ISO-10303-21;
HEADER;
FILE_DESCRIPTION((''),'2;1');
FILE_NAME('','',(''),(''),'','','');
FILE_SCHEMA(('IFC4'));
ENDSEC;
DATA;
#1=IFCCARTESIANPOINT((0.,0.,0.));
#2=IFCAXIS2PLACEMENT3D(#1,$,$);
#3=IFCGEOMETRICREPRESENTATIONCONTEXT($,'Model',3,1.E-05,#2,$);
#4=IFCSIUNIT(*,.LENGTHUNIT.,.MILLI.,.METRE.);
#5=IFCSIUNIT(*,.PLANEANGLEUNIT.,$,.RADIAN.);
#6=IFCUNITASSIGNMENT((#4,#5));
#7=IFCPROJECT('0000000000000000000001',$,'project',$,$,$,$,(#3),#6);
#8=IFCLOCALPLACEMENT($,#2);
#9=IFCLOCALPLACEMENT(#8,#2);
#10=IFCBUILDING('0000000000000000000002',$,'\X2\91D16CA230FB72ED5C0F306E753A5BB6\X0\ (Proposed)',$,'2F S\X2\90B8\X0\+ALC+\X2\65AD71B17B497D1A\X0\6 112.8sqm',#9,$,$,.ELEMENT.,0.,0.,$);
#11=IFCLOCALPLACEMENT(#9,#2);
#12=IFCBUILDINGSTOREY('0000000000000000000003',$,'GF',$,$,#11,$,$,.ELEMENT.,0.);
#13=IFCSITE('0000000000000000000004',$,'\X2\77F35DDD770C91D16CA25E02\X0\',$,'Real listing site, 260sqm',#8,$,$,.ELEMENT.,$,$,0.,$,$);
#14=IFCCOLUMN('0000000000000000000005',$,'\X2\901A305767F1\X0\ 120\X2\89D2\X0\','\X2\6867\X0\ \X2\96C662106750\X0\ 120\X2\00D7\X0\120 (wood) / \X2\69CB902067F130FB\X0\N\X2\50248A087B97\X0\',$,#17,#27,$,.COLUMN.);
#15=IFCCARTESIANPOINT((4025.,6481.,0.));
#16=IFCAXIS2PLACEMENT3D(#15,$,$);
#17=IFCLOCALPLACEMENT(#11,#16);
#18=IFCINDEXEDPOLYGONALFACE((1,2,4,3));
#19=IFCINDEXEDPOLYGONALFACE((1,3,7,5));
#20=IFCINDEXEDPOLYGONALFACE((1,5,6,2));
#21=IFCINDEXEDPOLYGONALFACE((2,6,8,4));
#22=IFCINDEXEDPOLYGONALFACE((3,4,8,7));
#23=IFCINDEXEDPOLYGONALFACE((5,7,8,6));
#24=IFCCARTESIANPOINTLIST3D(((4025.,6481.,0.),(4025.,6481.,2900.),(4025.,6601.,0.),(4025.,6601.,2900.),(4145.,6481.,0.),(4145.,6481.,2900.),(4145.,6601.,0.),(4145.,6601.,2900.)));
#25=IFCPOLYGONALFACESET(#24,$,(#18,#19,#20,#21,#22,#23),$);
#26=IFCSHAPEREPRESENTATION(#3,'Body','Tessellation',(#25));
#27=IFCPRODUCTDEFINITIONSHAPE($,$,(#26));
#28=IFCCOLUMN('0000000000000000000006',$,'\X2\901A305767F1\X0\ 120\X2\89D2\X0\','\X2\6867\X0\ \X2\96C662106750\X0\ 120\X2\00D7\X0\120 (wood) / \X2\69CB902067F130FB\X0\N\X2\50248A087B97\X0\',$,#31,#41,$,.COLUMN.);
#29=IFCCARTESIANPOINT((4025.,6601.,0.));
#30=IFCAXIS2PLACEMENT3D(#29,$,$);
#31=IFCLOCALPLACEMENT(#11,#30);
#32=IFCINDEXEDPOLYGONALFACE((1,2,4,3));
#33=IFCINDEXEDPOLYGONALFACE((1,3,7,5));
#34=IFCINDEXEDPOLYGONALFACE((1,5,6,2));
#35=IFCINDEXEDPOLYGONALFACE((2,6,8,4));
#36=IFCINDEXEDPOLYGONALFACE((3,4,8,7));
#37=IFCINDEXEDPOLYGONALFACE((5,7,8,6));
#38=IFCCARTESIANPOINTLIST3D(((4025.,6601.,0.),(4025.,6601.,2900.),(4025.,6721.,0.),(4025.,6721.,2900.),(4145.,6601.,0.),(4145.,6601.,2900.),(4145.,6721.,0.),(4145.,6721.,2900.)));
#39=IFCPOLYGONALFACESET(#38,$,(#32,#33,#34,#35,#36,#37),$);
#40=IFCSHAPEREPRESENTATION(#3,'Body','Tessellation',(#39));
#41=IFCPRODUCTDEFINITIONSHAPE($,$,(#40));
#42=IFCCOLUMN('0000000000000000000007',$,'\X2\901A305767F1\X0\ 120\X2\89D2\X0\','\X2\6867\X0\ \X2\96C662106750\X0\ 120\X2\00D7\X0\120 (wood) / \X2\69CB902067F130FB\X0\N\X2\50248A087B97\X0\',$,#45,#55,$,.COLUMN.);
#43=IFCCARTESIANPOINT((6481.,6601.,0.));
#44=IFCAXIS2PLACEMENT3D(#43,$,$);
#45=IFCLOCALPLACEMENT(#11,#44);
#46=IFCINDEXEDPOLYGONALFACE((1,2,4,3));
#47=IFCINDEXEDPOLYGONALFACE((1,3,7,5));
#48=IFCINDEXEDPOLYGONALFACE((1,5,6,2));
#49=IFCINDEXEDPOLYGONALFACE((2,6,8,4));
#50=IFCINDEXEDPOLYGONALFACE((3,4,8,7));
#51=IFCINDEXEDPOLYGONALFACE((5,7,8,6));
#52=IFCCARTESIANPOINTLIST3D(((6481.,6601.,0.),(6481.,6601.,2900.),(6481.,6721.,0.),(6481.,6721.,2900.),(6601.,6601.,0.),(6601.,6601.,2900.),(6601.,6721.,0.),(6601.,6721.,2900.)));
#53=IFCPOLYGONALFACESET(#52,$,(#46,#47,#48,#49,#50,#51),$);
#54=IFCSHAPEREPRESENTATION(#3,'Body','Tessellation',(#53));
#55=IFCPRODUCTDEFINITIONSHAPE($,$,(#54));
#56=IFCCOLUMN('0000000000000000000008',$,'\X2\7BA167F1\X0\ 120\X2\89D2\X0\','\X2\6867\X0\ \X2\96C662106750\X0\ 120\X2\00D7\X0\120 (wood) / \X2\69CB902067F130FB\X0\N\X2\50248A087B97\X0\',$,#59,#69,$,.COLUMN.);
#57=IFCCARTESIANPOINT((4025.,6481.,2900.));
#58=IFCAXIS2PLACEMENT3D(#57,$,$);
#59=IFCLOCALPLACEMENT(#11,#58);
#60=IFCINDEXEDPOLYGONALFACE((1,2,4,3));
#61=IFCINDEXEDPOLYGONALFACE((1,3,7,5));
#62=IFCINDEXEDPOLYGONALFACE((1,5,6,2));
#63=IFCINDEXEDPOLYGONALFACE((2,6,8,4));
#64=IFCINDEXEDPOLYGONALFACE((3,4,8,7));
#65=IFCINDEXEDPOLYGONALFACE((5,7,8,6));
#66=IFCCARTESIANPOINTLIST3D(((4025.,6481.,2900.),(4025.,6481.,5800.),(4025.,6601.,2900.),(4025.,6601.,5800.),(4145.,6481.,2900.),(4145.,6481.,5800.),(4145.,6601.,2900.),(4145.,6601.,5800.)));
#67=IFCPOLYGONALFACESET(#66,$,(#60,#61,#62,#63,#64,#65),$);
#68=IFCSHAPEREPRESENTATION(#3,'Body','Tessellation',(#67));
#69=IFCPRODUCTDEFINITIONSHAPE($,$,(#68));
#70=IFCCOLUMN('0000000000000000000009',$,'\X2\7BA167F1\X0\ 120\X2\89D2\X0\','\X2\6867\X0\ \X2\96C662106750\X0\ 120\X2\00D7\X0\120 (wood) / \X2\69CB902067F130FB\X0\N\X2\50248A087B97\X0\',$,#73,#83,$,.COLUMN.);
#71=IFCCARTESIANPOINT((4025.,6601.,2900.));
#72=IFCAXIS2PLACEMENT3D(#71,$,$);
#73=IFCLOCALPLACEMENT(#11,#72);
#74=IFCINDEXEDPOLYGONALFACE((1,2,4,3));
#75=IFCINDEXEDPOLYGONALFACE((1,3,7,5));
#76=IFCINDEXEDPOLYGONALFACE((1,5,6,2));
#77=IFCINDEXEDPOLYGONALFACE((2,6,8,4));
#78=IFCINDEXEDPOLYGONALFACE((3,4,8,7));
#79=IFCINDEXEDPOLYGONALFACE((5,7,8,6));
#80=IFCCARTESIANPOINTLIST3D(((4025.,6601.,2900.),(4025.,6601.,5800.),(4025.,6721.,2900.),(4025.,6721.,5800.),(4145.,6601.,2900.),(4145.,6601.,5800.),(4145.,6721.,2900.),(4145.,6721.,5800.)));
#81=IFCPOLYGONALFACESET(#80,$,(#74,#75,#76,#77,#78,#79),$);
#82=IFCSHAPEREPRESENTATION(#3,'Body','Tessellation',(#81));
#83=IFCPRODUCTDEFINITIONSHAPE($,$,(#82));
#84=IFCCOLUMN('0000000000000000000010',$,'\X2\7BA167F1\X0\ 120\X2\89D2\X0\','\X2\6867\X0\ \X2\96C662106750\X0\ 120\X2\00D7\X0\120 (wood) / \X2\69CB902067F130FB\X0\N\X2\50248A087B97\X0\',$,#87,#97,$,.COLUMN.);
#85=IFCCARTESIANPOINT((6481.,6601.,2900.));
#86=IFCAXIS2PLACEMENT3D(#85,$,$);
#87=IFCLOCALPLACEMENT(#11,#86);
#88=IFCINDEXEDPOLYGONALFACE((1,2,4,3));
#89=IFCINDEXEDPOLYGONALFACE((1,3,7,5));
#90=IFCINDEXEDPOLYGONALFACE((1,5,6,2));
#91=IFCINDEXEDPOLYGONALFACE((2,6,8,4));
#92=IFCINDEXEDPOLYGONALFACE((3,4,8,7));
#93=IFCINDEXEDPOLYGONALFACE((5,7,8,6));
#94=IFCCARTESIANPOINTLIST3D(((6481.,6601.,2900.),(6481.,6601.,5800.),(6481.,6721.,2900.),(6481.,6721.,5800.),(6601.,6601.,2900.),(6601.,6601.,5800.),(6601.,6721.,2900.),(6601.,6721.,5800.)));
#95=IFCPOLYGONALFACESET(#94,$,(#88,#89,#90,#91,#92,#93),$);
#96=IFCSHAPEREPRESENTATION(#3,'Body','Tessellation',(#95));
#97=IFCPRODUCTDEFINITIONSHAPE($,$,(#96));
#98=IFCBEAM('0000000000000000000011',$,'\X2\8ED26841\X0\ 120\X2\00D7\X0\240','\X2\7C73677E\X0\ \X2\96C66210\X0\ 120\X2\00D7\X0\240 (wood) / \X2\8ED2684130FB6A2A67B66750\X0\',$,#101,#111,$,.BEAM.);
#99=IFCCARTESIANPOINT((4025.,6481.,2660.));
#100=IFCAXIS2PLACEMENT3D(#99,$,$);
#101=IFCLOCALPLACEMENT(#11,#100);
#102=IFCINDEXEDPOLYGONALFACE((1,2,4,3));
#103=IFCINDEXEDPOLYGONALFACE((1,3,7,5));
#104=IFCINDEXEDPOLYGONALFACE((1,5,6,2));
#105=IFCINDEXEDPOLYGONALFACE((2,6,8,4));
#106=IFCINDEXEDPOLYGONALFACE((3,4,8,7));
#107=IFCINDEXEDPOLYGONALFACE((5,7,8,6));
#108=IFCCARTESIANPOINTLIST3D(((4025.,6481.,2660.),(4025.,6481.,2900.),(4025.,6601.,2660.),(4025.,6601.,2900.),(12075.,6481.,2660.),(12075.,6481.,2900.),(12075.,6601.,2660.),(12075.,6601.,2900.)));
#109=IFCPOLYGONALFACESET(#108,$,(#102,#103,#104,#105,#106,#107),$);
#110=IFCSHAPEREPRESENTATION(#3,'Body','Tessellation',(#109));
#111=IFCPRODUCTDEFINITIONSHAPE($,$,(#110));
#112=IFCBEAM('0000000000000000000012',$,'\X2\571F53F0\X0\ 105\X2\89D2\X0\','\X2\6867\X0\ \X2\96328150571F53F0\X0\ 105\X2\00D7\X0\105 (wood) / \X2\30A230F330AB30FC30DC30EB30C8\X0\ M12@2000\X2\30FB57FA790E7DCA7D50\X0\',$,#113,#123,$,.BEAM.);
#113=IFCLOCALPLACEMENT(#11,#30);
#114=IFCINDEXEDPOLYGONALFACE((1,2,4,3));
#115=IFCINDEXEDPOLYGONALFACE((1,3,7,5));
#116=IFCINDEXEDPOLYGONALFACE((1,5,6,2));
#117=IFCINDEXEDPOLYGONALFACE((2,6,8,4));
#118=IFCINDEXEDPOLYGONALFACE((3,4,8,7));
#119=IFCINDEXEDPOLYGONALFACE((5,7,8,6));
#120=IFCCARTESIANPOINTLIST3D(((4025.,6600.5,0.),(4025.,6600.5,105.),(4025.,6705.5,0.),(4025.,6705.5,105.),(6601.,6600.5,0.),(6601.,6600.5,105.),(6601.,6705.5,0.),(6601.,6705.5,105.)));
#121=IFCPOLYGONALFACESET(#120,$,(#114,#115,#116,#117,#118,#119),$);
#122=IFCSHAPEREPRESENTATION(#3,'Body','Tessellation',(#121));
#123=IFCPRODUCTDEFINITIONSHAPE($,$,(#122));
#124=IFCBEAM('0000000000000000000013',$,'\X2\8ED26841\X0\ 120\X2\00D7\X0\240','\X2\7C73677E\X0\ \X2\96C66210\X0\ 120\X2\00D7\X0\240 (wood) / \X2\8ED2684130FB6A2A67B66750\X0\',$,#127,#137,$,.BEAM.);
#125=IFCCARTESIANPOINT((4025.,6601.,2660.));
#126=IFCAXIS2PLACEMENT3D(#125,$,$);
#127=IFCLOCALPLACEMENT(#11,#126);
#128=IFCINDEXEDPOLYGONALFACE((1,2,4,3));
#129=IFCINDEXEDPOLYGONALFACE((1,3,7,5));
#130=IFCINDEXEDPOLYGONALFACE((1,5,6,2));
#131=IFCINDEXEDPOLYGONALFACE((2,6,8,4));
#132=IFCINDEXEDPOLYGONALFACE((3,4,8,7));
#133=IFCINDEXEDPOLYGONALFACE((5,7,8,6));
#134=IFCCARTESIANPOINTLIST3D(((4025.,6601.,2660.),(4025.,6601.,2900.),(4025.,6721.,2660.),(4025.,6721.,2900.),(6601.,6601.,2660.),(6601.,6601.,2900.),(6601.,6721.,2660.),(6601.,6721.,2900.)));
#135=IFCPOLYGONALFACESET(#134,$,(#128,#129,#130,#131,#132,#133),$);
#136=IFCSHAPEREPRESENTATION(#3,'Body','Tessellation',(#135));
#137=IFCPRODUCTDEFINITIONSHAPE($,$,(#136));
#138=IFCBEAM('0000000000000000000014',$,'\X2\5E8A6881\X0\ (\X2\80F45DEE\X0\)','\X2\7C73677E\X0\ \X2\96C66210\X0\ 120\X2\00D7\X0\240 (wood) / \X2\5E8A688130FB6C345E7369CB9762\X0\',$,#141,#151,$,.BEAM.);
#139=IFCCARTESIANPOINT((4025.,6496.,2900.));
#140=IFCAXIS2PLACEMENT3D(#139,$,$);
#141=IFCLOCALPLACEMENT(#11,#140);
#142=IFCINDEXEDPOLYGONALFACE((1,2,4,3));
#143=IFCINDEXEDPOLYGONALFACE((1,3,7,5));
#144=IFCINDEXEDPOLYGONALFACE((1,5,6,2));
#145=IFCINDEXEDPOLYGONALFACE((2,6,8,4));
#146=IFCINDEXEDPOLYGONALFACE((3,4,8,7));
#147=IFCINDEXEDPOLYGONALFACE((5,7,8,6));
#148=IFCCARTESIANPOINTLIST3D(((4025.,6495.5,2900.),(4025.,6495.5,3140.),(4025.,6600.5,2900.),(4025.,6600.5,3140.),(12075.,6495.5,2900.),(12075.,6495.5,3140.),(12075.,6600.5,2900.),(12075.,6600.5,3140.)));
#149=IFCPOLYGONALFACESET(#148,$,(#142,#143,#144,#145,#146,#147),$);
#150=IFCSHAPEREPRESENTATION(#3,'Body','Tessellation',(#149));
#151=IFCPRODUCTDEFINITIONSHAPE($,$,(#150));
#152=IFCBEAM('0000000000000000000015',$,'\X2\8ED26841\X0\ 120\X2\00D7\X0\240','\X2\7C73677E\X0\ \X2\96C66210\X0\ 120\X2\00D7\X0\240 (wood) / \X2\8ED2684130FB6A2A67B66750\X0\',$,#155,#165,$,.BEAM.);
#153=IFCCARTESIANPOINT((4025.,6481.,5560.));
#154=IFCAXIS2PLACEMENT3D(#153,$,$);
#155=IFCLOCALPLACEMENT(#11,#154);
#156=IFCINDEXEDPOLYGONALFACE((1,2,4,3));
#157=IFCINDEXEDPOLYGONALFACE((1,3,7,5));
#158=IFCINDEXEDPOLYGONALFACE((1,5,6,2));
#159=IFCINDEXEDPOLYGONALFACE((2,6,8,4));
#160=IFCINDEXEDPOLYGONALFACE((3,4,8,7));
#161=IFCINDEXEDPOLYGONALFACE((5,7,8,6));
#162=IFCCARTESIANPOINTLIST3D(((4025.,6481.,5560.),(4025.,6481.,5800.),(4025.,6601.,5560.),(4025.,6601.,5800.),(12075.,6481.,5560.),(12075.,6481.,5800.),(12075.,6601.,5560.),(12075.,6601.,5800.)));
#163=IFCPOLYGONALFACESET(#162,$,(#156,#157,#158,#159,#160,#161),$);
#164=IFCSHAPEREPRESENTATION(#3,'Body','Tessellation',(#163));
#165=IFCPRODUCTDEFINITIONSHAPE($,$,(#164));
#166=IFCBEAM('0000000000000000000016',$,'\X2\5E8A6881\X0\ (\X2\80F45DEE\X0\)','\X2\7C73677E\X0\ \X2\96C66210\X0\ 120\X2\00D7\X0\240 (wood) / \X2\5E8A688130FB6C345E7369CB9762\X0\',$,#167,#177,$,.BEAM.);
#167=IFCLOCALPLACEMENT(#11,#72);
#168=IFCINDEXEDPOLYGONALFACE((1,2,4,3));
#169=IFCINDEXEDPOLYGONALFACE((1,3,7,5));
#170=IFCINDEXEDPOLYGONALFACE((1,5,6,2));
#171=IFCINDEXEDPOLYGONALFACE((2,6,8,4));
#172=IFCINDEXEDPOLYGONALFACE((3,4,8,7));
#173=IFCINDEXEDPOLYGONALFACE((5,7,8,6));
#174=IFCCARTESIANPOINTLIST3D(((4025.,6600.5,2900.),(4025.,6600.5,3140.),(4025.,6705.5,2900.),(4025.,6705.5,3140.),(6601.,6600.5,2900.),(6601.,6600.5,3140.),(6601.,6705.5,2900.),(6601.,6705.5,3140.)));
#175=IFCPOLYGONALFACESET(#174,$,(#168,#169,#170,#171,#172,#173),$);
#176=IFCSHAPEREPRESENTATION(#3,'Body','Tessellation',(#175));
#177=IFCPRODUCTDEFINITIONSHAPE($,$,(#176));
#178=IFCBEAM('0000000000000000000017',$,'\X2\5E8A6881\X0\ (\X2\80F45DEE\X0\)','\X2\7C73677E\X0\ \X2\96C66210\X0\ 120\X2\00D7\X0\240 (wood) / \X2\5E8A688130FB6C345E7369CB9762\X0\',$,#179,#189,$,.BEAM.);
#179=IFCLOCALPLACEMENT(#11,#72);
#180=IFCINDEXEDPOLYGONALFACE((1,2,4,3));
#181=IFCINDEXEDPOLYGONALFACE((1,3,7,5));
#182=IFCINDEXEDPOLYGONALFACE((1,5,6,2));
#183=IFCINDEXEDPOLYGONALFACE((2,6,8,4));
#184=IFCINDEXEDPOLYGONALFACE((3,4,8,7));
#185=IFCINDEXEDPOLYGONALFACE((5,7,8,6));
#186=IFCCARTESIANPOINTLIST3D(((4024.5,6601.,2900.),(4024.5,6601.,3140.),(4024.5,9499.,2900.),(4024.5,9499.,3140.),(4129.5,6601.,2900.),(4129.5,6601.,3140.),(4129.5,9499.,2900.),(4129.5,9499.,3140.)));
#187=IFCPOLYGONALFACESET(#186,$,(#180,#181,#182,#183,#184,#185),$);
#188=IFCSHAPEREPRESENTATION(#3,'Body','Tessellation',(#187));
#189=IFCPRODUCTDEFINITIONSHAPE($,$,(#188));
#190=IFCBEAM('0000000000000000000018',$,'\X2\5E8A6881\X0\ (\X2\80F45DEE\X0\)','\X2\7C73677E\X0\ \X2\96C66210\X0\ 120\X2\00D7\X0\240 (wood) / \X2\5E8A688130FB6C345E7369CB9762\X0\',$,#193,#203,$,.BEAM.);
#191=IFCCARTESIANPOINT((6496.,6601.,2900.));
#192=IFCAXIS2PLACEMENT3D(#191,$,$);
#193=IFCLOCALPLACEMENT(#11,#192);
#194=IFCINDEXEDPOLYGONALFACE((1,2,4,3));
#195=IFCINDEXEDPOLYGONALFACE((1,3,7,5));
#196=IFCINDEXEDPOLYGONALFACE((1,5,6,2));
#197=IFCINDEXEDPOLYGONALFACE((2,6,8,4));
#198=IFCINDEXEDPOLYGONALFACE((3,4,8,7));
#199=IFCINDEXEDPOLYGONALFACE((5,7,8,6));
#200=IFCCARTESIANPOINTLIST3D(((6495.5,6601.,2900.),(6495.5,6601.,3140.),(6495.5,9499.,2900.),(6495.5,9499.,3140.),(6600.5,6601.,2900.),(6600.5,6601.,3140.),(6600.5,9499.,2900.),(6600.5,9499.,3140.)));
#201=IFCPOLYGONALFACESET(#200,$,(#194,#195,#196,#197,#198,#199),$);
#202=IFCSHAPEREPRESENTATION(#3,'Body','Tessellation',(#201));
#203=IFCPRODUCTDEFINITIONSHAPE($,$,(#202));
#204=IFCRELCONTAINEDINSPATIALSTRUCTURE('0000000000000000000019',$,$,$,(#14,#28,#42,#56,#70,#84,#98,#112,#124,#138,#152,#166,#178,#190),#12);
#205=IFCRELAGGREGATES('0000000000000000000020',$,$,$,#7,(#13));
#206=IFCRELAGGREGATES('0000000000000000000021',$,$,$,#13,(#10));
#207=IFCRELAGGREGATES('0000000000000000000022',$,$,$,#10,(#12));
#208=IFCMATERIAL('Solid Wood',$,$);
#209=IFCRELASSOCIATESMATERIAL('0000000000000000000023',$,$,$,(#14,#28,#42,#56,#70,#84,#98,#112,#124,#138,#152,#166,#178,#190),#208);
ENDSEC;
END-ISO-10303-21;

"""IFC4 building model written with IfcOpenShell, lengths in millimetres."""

from ifc_helpers import new_model, si_unit, frame, frame_2d, origin, place, context, project, spatial, rectangle, extrude, material, element, save


model = new_model("IFC4")

# Units and contexts
model_context = context("Model", 3, precision=1e-05, world=origin())
ifc_project = project(units=[si_unit("LENGTHUNIT", "METRE", prefix="MILLI"), si_unit("PLANEANGLEUNIT", "RADIAN")], contexts=[model_context])

# Site, building, storey
site_placement = place(None, origin())
site = spatial("IfcSite", under=ifc_project, at=site_placement, Name="石川県金沢市", ObjectType="Real listing site, 260sqm", CompositionType="ELEMENT", RefElevation=0.0)
building_placement = place(site_placement, origin())
building = spatial("IfcBuilding", under=site, at=building_placement, Name="金沢・狭小の町家 (Proposed)", ObjectType="2F S邸+ALC+断熱等級6 112.8sqm", CompositionType="ELEMENT", ElevationOfRefHeight=0.0, ElevationOfTerrain=0.0)
storey_placement = place(building_placement, origin())
storey = spatial("IfcBuildingStorey", under=building, at=storey_placement, Name="GF", CompositionType="ELEMENT", Elevation=0.0)

# Columns
ifc_material_1 = material(Name="Solid Wood")
column_1_placement = place(storey_placement, frame((4025.0, 6481.0, 0.0)))
element("IfcColumn", 1, at=column_1_placement, inside=storey, material=ifc_material_1, Name="通し柱 120角", Description="桧 集成材 120×120 (wood) / 構造柱・N値計算", PredefinedType="COLUMN", context=model_context, shape_type="SweptSolid", body=[
    extrude(rectangle(XDim=120.0, YDim=120.0, at=frame_2d((60.0, 60.0))), frame((4025.0, 6481.0, 0.0)), (0.0, 0.0, 1.0), 2900.0),
])
column_2_placement = place(storey_placement, frame((4025.0, 6601.0, 0.0)))
element("IfcColumn", 2, at=column_2_placement, inside=storey, material=ifc_material_1, Name="通し柱 120角", Description="桧 集成材 120×120 (wood) / 構造柱・N値計算", PredefinedType="COLUMN", context=model_context, shape_type="SweptSolid", body=[
    extrude(rectangle(XDim=120.0, YDim=120.0, at=frame_2d((60.0, 60.0))), frame((4025.0, 6601.0, 0.0)), (0.0, 0.0, 1.0), 2900.0),
])
column_3_placement = place(storey_placement, frame((6481.0, 6601.0, 0.0)))
element("IfcColumn", 3, at=column_3_placement, inside=storey, material=ifc_material_1, Name="通し柱 120角", Description="桧 集成材 120×120 (wood) / 構造柱・N値計算", PredefinedType="COLUMN", context=model_context, shape_type="SweptSolid", body=[
    extrude(rectangle(XDim=120.0, YDim=120.0, at=frame_2d((60.0, 60.0))), frame((6481.0, 6601.0, 0.0)), (0.0, 0.0, 1.0), 2900.0),
])
column_4_placement = place(storey_placement, frame((4025.0, 6481.0, 2900.0)))
element("IfcColumn", 4, at=column_4_placement, inside=storey, material=ifc_material_1, Name="管柱 120角", Description="桧 集成材 120×120 (wood) / 構造柱・N値計算", PredefinedType="COLUMN", context=model_context, shape_type="SweptSolid", body=[
    extrude(rectangle(XDim=120.0, YDim=120.0, at=frame_2d((60.0, 60.0))), frame((4025.0, 6481.0, 2900.0)), (0.0, 0.0, 1.0), 2900.0),
])
column_5_placement = place(storey_placement, frame((4025.0, 6601.0, 2900.0)))
element("IfcColumn", 5, at=column_5_placement, inside=storey, material=ifc_material_1, Name="管柱 120角", Description="桧 集成材 120×120 (wood) / 構造柱・N値計算", PredefinedType="COLUMN", context=model_context, shape_type="SweptSolid", body=[
    extrude(rectangle(XDim=120.0, YDim=120.0, at=frame_2d((60.0, 60.0))), frame((4025.0, 6601.0, 2900.0)), (0.0, 0.0, 1.0), 2900.0),
])
column_6_placement = place(storey_placement, frame((6481.0, 6601.0, 2900.0)))
element("IfcColumn", 6, at=column_6_placement, inside=storey, material=ifc_material_1, Name="管柱 120角", Description="桧 集成材 120×120 (wood) / 構造柱・N値計算", PredefinedType="COLUMN", context=model_context, shape_type="SweptSolid", body=[
    extrude(rectangle(XDim=120.0, YDim=120.0, at=frame_2d((60.0, 60.0))), frame((6481.0, 6601.0, 2900.0)), (0.0, 0.0, 1.0), 2900.0),
])

# Beams
beam_1_placement = place(storey_placement, frame((4025.0, 6481.0, 2660.0)))
element("IfcBeam", 7, at=beam_1_placement, inside=storey, material=ifc_material_1, Name="軒桁 120×240", Description="米松 集成 120×240 (wood) / 軒桁・横架材", PredefinedType="BEAM", context=model_context, shape_type="SweptSolid", body=[
    extrude(rectangle(XDim=8050.0, YDim=120.0, at=frame_2d((4025.0, 60.0))), frame((4025.0, 6481.0, 2660.0)), (0.0, 0.0, 1.0), 240.0),
])
beam_2_placement = place(storey_placement, frame((4025.0, 6601.0, 0.0)))
element("IfcBeam", 8, at=beam_2_placement, inside=storey, material=ifc_material_1, Name="土台 105角", Description="桧 防腐土台 105×105 (wood) / アンカーボルト M12@2000・基礎緊結", PredefinedType="BEAM", context=model_context, shape_type="SweptSolid", body=[
    extrude(rectangle(XDim=2576.0, YDim=105.0, at=frame_2d((1288.0, 52.0))), frame((4025.0, 6601.0, 0.0)), (0.0, 0.0, 1.0), 105.0),
])
beam_3_placement = place(storey_placement, frame((4025.0, 6601.0, 2660.0)))
element("IfcBeam", 9, at=beam_3_placement, inside=storey, material=ifc_material_1, Name="軒桁 120×240", Description="米松 集成 120×240 (wood) / 軒桁・横架材", PredefinedType="BEAM", context=model_context, shape_type="SweptSolid", body=[
    extrude(rectangle(XDim=2576.0, YDim=120.0, at=frame_2d((1288.0, 60.0))), frame((4025.0, 6601.0, 2660.0)), (0.0, 0.0, 1.0), 240.0),
])
beam_4_placement = place(storey_placement, frame((4025.0, 6496.0, 2900.0)))
element("IfcBeam", 10, at=beam_4_placement, inside=storey, material=ifc_material_1, Name="床梁 (胴差)", Description="米松 集成 120×240 (wood) / 床梁・水平構面", PredefinedType="BEAM", context=model_context, shape_type="SweptSolid", body=[
    extrude(rectangle(XDim=8050.0, YDim=105.0, at=frame_2d((4025.0, 52.0))), frame((4025.0, 6496.0, 2900.0)), (0.0, 0.0, 1.0), 240.0),
])
beam_5_placement = place(storey_placement, frame((4025.0, 6481.0, 5560.0)))
element("IfcBeam", 11, at=beam_5_placement, inside=storey, material=ifc_material_1, Name="軒桁 120×240", Description="米松 集成 120×240 (wood) / 軒桁・横架材", PredefinedType="BEAM", context=model_context, shape_type="SweptSolid", body=[
    extrude(rectangle(XDim=8050.0, YDim=120.0, at=frame_2d((4025.0, 60.0))), frame((4025.0, 6481.0, 5560.0)), (0.0, 0.0, 1.0), 240.0),
])
beam_6_placement = place(storey_placement, frame((4025.0, 6601.0, 2900.0)))
element("IfcBeam", 12, at=beam_6_placement, inside=storey, material=ifc_material_1, Name="床梁 (胴差)", Description="米松 集成 120×240 (wood) / 床梁・水平構面", PredefinedType="BEAM", context=model_context, shape_type="SweptSolid", body=[
    extrude(rectangle(XDim=2576.0, YDim=105.0, at=frame_2d((1288.0, 52.0))), frame((4025.0, 6601.0, 2900.0)), (0.0, 0.0, 1.0), 240.0),
])
beam_7_placement = place(storey_placement, frame((4025.0, 6601.0, 2900.0)))
element("IfcBeam", 13, at=beam_7_placement, inside=storey, material=ifc_material_1, Name="床梁 (胴差)", Description="米松 集成 120×240 (wood) / 床梁・水平構面", PredefinedType="BEAM", context=model_context, shape_type="SweptSolid", body=[
    extrude(rectangle(XDim=105.0, YDim=2898.0, at=frame_2d((52.0, 1449.0))), frame((4025.0, 6601.0, 2900.0)), (0.0, 0.0, 1.0), 240.0),
])
beam_8_placement = place(storey_placement, frame((6496.0, 6601.0, 2900.0)))
element("IfcBeam", 14, at=beam_8_placement, inside=storey, material=ifc_material_1, Name="床梁 (胴差)", Description="米松 集成 120×240 (wood) / 床梁・水平構面", PredefinedType="BEAM", context=model_context, shape_type="SweptSolid", body=[
    extrude(rectangle(XDim=105.0, YDim=2898.0, at=frame_2d((52.0, 1449.0))), frame((6496.0, 6601.0, 2900.0)), (0.0, 0.0, 1.0), 240.0),
])

save(model, "model.ifc")
